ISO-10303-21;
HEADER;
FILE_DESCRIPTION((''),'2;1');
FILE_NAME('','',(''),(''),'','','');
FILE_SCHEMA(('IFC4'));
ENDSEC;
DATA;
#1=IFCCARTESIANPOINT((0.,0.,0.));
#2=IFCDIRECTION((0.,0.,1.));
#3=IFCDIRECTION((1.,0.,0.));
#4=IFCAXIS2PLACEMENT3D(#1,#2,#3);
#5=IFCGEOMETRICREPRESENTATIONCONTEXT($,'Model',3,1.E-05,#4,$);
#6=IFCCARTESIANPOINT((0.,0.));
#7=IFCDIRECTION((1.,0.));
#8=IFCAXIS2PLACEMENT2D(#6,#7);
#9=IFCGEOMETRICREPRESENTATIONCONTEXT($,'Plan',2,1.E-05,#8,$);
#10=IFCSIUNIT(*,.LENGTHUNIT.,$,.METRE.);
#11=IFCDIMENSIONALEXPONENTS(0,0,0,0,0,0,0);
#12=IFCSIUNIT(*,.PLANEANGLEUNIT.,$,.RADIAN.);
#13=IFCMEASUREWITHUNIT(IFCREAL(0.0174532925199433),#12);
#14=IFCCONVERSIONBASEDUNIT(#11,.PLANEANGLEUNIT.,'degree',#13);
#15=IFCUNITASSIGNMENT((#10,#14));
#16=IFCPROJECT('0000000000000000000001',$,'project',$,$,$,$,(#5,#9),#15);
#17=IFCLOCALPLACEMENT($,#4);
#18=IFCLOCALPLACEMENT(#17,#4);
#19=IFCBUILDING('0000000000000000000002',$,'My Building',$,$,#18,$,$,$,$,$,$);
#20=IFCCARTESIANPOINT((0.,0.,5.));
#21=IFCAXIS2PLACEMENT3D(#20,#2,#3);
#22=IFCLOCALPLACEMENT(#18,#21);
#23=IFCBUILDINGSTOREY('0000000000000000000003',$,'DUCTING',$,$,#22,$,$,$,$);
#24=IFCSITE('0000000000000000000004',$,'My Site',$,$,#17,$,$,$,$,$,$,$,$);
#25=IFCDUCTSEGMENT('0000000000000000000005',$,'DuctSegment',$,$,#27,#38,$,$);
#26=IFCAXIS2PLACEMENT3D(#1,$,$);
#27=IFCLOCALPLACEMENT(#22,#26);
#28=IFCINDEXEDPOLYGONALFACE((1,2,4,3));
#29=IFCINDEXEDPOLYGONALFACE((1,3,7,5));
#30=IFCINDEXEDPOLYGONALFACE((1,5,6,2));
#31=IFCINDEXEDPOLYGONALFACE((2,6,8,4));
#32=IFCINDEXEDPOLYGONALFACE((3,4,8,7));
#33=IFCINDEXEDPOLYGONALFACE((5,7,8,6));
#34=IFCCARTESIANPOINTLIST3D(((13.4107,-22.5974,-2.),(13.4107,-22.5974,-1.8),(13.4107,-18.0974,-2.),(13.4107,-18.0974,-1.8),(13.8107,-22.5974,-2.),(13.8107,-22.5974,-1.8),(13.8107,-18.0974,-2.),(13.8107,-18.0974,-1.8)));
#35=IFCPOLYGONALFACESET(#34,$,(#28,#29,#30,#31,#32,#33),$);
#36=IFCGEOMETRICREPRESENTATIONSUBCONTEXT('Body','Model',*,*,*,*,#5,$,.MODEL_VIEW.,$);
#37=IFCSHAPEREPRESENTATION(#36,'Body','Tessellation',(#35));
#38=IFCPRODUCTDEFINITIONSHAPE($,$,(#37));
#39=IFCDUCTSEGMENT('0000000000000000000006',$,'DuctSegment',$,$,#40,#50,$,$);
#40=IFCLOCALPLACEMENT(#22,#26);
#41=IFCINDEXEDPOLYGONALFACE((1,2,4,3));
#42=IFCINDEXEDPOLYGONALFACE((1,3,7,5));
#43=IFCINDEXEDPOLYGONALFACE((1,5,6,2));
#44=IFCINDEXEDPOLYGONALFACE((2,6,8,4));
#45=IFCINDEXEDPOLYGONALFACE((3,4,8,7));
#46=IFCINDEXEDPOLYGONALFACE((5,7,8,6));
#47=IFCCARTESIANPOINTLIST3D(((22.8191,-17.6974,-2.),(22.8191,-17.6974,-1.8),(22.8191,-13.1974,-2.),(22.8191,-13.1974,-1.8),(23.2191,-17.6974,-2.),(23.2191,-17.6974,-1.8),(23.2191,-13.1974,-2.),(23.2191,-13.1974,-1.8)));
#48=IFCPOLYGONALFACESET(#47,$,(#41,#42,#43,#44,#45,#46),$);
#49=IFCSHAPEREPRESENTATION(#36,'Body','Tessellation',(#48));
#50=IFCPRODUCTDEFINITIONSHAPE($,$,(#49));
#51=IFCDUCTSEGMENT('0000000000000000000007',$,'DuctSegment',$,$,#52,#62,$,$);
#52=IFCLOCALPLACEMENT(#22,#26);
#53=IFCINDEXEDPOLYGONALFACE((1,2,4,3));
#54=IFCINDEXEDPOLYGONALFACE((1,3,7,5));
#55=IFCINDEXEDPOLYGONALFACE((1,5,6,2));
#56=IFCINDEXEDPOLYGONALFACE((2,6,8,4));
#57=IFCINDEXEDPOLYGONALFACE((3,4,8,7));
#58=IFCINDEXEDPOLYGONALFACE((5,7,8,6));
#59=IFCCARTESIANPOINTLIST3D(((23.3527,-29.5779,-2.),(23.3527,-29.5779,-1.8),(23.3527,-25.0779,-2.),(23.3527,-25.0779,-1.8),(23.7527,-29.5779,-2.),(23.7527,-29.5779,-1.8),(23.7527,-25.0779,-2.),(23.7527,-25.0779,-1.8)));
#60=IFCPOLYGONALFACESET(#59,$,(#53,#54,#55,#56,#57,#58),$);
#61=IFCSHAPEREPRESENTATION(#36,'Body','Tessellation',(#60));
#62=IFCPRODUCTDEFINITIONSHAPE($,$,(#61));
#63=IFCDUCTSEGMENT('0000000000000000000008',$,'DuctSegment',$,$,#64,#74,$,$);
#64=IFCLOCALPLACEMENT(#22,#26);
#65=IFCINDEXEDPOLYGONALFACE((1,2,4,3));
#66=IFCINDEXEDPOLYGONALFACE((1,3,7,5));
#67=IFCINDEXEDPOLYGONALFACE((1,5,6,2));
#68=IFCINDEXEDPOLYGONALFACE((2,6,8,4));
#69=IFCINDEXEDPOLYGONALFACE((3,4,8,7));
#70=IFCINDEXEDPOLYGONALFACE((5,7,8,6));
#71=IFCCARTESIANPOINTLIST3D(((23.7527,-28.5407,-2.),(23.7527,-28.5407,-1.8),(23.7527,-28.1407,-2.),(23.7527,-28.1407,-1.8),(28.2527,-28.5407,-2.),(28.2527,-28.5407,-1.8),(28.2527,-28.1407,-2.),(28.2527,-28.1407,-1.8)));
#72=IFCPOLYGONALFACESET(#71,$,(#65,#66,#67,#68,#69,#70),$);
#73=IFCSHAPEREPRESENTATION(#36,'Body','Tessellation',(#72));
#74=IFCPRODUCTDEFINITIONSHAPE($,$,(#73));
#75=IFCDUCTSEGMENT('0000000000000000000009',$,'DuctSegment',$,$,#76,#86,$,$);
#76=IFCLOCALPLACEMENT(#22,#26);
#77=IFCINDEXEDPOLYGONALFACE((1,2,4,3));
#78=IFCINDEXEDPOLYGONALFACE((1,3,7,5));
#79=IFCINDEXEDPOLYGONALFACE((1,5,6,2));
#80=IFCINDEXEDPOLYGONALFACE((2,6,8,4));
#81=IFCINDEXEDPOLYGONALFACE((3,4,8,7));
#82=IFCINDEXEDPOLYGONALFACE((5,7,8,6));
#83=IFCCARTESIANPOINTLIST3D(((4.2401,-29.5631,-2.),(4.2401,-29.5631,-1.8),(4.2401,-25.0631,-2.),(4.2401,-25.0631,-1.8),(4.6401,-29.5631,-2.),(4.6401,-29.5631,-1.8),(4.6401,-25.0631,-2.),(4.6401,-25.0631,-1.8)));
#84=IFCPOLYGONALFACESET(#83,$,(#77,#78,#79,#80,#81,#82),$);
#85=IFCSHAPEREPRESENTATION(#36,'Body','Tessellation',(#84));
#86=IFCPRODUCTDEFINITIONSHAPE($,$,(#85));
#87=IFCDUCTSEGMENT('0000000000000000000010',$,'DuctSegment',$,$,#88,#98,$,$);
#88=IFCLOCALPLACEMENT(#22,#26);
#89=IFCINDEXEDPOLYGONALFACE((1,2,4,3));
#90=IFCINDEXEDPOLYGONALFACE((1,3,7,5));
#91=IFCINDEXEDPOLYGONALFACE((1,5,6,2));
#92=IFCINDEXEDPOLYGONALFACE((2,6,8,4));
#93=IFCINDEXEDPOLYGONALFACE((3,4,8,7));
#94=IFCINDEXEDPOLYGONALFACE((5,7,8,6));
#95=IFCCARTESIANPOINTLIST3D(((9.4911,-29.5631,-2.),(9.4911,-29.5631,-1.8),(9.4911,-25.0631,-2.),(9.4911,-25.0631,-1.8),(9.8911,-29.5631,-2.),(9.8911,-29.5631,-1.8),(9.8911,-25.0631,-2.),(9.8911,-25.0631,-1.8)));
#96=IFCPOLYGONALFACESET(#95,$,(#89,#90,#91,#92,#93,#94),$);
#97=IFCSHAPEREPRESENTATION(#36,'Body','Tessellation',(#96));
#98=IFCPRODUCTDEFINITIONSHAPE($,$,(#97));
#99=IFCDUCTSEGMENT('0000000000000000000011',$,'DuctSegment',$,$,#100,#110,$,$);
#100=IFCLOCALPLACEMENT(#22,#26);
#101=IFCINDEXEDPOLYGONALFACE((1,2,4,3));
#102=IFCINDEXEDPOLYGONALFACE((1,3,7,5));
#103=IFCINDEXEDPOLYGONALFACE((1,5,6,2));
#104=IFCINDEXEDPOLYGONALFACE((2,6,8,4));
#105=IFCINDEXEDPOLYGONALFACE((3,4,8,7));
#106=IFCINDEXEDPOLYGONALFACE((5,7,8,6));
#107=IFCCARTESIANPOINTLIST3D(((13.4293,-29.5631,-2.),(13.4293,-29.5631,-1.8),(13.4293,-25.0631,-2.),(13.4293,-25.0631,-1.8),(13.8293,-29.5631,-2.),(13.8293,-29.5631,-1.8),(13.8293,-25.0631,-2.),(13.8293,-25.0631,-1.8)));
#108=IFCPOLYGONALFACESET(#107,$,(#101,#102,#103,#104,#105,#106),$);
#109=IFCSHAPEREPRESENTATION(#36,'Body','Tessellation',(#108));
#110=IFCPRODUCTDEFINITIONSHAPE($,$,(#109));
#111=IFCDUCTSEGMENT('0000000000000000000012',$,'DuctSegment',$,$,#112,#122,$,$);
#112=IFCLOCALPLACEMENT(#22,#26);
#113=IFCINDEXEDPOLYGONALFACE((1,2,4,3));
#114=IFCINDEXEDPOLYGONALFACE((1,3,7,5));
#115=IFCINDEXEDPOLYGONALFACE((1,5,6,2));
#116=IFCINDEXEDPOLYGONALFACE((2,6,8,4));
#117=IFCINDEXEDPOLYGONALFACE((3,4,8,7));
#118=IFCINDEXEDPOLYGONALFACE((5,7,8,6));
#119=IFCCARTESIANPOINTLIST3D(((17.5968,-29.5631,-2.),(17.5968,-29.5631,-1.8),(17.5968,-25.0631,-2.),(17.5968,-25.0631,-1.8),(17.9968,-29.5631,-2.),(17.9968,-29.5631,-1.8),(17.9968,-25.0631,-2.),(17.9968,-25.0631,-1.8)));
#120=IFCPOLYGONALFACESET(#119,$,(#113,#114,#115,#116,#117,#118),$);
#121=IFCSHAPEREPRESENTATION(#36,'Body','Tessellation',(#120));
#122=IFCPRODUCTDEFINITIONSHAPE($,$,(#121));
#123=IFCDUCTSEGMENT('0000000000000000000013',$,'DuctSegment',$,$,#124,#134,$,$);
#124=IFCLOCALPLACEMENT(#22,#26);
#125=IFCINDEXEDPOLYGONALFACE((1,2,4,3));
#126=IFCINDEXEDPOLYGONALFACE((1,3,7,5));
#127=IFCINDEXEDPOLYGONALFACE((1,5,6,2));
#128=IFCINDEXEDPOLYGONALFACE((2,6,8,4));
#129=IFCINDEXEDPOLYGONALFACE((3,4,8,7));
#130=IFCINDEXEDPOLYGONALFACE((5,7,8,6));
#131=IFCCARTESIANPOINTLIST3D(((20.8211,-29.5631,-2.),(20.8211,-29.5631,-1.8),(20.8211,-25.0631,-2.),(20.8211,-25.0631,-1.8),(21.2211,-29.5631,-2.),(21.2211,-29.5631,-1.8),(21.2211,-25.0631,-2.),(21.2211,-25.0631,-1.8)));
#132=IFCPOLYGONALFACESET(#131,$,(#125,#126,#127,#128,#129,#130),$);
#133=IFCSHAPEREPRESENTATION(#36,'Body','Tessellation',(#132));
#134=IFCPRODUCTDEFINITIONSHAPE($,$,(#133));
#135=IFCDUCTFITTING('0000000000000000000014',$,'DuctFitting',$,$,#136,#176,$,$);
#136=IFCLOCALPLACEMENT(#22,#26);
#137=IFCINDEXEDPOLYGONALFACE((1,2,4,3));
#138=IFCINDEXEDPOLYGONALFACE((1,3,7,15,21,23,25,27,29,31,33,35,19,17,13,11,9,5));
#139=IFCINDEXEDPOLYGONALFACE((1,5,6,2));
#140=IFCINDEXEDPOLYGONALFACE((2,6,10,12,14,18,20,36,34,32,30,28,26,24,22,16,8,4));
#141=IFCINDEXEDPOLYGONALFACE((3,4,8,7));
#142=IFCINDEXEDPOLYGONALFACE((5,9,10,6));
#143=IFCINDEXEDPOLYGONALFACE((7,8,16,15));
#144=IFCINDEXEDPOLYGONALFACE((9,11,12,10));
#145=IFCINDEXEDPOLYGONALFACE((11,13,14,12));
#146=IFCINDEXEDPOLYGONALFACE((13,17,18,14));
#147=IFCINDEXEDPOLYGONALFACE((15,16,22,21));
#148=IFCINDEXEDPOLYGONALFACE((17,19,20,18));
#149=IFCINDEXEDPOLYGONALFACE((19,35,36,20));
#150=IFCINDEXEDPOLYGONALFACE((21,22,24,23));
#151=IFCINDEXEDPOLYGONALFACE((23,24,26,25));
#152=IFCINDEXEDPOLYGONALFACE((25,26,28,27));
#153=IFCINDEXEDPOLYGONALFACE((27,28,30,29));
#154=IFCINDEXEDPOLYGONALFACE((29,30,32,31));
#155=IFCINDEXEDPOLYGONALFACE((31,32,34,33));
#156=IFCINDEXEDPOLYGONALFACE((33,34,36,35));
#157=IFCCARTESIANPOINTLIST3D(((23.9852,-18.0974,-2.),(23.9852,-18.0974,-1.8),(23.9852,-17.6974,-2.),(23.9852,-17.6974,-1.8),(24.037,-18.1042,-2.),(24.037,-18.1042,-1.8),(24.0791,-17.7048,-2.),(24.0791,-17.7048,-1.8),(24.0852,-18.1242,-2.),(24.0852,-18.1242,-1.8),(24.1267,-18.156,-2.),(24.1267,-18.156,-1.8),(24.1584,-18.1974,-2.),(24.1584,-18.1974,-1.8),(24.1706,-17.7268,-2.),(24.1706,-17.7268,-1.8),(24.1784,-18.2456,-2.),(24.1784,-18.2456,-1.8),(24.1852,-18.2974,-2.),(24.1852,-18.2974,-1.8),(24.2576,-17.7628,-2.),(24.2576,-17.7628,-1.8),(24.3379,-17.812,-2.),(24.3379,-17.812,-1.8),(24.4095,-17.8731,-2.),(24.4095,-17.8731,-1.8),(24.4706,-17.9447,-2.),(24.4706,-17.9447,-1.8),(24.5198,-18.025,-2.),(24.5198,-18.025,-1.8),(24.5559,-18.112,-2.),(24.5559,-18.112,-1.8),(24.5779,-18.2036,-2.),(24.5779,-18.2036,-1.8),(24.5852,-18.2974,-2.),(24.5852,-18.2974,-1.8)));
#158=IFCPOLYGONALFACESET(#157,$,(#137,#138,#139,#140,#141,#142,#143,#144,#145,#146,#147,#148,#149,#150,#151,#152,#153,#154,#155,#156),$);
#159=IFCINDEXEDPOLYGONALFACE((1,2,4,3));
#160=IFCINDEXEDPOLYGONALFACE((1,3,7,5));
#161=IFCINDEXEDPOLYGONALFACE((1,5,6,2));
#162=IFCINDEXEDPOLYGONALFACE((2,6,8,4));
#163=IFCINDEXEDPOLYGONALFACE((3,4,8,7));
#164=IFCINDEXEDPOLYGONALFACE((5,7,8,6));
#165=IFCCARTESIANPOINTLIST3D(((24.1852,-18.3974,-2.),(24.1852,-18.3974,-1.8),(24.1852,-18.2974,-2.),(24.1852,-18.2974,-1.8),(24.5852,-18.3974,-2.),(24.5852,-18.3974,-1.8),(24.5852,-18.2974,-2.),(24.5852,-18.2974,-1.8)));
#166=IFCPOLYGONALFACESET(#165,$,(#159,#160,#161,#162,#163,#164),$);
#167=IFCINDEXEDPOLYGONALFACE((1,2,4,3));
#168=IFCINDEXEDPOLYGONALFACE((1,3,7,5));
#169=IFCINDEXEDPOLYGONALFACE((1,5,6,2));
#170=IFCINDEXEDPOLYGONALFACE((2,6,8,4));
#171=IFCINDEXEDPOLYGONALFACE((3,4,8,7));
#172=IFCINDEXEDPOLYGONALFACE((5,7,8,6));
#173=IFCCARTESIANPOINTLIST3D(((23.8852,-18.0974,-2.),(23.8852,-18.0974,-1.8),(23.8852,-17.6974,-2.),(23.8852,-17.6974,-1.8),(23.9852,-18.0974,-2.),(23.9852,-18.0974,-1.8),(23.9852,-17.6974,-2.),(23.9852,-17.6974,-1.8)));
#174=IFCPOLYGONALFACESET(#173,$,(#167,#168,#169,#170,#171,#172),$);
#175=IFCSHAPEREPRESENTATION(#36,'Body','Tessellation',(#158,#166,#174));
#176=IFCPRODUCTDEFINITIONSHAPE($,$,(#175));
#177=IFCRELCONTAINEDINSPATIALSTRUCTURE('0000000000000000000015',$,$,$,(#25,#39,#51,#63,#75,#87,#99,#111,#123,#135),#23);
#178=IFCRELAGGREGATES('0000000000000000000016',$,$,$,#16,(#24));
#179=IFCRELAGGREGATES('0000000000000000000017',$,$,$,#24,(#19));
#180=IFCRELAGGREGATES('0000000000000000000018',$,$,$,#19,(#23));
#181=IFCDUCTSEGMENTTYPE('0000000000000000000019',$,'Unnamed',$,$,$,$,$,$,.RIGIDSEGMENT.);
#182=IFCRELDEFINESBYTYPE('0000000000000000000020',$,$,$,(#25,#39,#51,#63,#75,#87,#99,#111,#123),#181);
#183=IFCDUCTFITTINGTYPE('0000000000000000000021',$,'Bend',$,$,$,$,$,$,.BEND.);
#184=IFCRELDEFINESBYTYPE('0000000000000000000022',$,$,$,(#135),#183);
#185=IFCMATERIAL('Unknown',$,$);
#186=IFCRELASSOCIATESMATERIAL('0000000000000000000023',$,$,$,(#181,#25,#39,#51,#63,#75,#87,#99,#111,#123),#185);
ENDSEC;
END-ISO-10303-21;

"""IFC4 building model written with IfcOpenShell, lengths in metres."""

from ifc_helpers import new_model, entity, si_unit, converted_unit, frame, origin_with_axes, origin_2d_with_axis, place, context, subcontext, project, spatial, line, arc, indexed_curve, rectangle, outline, extrude, source, transform, mapped, material, material_profile, profile_set, profile_usage, type_object, type_shapes, element, save


model = new_model("IFC4")

# Units and contexts
model_context = context("Model", 3, precision=1e-05, world=origin_with_axes())
plan_context = context("Plan", 2, precision=1e-05, world=origin_2d_with_axis())
body_context = subcontext(model_context, "Body", "Model", "MODEL_VIEW")
ifc_project = project(units=[si_unit("LENGTHUNIT", "METRE"), converted_unit("PLANEANGLEUNIT", "degree", entity("IfcReal", 0.0174532925199433), si_unit("PLANEANGLEUNIT", "RADIAN"), dimensions=[0, 0, 0, 0, 0, 0, 0])], contexts=[model_context, plan_context])

# Site, building, storey
site_placement = place(None, origin_with_axes())
site = spatial("IfcSite", under=ifc_project, at=site_placement, Name="My Site")
building_placement = place(site_placement, origin_with_axes())
building = spatial("IfcBuilding", under=site, at=building_placement, Name="My Building")
storey_placement = place(building_placement, frame((0.0, 0.0, 5.0), z_axis=(0.0, 0.0, 1.0), x_axis=(1.0, 0.0, 0.0)))
storey = spatial("IfcBuildingStorey", under=building, at=storey_placement, Name="DUCTING")

# Duct segments
ifc_material = material(Name="Unknown")
ifc_material_profile = material_profile(ifc_material, rectangle(XDim=0.4, YDim=0.2))
ifc_profile_set = profile_set([ifc_material_profile])
duct_segment_type = type_object("IfcDuctSegmentType", Name="Unnamed", PredefinedType="RIGIDSEGMENT", material=ifc_profile_set)
ifc_profile_usage_1 = profile_usage(ifc_profile_set, cardinal=5)
duct_segment_1_placement = place(storey_placement, frame((13.6107, -22.5974, -1.9), z_axis=(0.0, 1.0, -0.000003), x_axis=(-1.0, 0.0, 0.0)))
element("IfcDuctSegment", 1, at=duct_segment_1_placement, inside=storey, type_object=duct_segment_type, material=ifc_profile_usage_1, Name="DuctSegment", context=body_context, shape_type="SweptSolid", body=[
    extrude(rectangle(XDim=0.4, YDim=0.2), origin_with_axes(), (0.0, 0.0, 1.0), 4.5),
])
ifc_profile_usage_2 = profile_usage(ifc_profile_set, cardinal=5)
duct_segment_2_placement = place(storey_placement, frame((23.0191, -17.6974, -1.9), z_axis=(0.0, 1.0, -0.000003), x_axis=(-1.0, 0.0, 0.0)))
element("IfcDuctSegment", 2, at=duct_segment_2_placement, inside=storey, type_object=duct_segment_type, material=ifc_profile_usage_2, Name="DuctSegment", context=body_context, shape_type="SweptSolid", body=[
    extrude(rectangle(XDim=0.4, YDim=0.2), origin_with_axes(), (0.0, 0.0, 1.0), 4.5),
])
ifc_profile_usage_3 = profile_usage(ifc_profile_set, cardinal=5)
duct_segment_3_placement = place(storey_placement, frame((23.5527, -29.5779, -1.9), z_axis=(0.0, 1.0, -0.000003), x_axis=(-1.0, 0.0, 0.0)))
element("IfcDuctSegment", 3, at=duct_segment_3_placement, inside=storey, type_object=duct_segment_type, material=ifc_profile_usage_3, Name="DuctSegment", context=body_context, shape_type="SweptSolid", body=[
    extrude(rectangle(XDim=0.4, YDim=0.2), origin_with_axes(), (0.0, 0.0, 1.0), 4.5),
])
ifc_profile_usage_4 = profile_usage(ifc_profile_set, cardinal=5)
duct_segment_4_placement = place(storey_placement, frame((28.2527, -28.3407, -1.9), z_axis=(-1.0, 0.0, -0.000003), x_axis=(0.0, -1.0, 0.0)))
element("IfcDuctSegment", 4, at=duct_segment_4_placement, inside=storey, type_object=duct_segment_type, material=ifc_profile_usage_4, Name="DuctSegment", context=body_context, shape_type="SweptSolid", body=[
    extrude(rectangle(XDim=0.4, YDim=0.2), origin_with_axes(), (0.0, 0.0, 1.0), 4.5),
])
ifc_profile_usage_5 = profile_usage(ifc_profile_set, cardinal=5)
duct_segment_5_placement = place(storey_placement, frame((4.4401, -29.5631, -1.9), z_axis=(0.0, 1.0, -0.000003), x_axis=(-1.0, 0.0, 0.0)))
element("IfcDuctSegment", 5, at=duct_segment_5_placement, inside=storey, type_object=duct_segment_type, material=ifc_profile_usage_5, Name="DuctSegment", context=body_context, shape_type="SweptSolid", body=[
    extrude(rectangle(XDim=0.4, YDim=0.2), origin_with_axes(), (0.0, 0.0, 1.0), 4.5),
])
ifc_profile_usage_6 = profile_usage(ifc_profile_set, cardinal=5)
duct_segment_6_placement = place(storey_placement, frame((9.6911, -29.5631, -1.9), z_axis=(0.0, 1.0, -0.000003), x_axis=(-1.0, 0.0, 0.0)))
element("IfcDuctSegment", 6, at=duct_segment_6_placement, inside=storey, type_object=duct_segment_type, material=ifc_profile_usage_6, Name="DuctSegment", context=body_context, shape_type="SweptSolid", body=[
    extrude(rectangle(XDim=0.4, YDim=0.2), origin_with_axes(), (0.0, 0.0, 1.0), 4.5),
])
ifc_profile_usage_7 = profile_usage(ifc_profile_set, cardinal=5)
duct_segment_7_placement = place(storey_placement, frame((13.6293, -29.5631, -1.9), z_axis=(0.0, 1.0, -0.000003), x_axis=(-1.0, 0.0, 0.0)))
element("IfcDuctSegment", 7, at=duct_segment_7_placement, inside=storey, type_object=duct_segment_type, material=ifc_profile_usage_7, Name="DuctSegment", context=body_context, shape_type="SweptSolid", body=[
    extrude(rectangle(XDim=0.4, YDim=0.2), origin_with_axes(), (0.0, 0.0, 1.0), 4.5),
])
ifc_profile_usage_8 = profile_usage(ifc_profile_set, cardinal=5)
duct_segment_8_placement = place(storey_placement, frame((17.7968, -29.5631, -1.9), z_axis=(0.0, 1.0, -0.000003), x_axis=(-1.0, 0.0, 0.0)))
element("IfcDuctSegment", 8, at=duct_segment_8_placement, inside=storey, type_object=duct_segment_type, material=ifc_profile_usage_8, Name="DuctSegment", context=body_context, shape_type="SweptSolid", body=[
    extrude(rectangle(XDim=0.4, YDim=0.2), origin_with_axes(), (0.0, 0.0, 1.0), 4.5),
])
ifc_profile_usage_9 = profile_usage(ifc_profile_set, cardinal=5)
duct_segment_9_placement = place(storey_placement, frame((21.0211, -29.5631, -1.9), z_axis=(0.0, 1.0, -0.000003), x_axis=(-1.0, 0.0, 0.0)))
element("IfcDuctSegment", 9, at=duct_segment_9_placement, inside=storey, type_object=duct_segment_type, material=ifc_profile_usage_9, Name="DuctSegment", context=body_context, shape_type="SweptSolid", body=[
    extrude(rectangle(XDim=0.4, YDim=0.2), origin_with_axes(), (0.0, 0.0, 1.0), 4.5),
])

# Duct fitting
duct_fitting_type = type_object("IfcDuctFittingType", Name="Bend", PredefinedType="BEND")
shared_shape = source(origin_with_axes(), body_context, "Body", "SweptSolid", [
    extrude(outline(indexed_curve([(-0.2, 0.0), (-0.2586, -0.1414), (-0.4, -0.2), (-0.4, -0.6), (0.0243, -0.4243), (0.2, 0.0)], segments=[arc(1, 2, 3), line(3, 4), arc(4, 5, 6), line(6, 1)])), frame((0.0, -0.1, -0.1), z_axis=(0.0, -1.0, 0.0), x_axis=(1.0, 0.0, 0.0)), (0.0, 0.0, -1.0), 0.2),
    extrude(rectangle(XDim=0.4, YDim=0.2), origin_with_axes(), (0.0, 0.0, -1.0), 0.1),
    extrude(rectangle(XDim=0.4, YDim=0.2), frame((-0.4, 0.0, -0.5), z_axis=(-1.0, 0.0, 0.0), x_axis=(0.0, 0.0, -1.0)), (0.0, 0.0, 1.0), 0.1),
])
type_shapes(duct_fitting_type, [shared_shape])
for number, where, z_axis, x_axis, name in (
    (10, (24.3852, -18.3974, -1.9), (0.0, -1.0, 0.0), (1.0, 0.0, 0.0), "DuctFitting"),
):
    element("IfcDuctFitting", number, at=place(storey_placement, frame(where, z_axis=z_axis, x_axis=x_axis)), inside=storey, type_object=duct_fitting_type, Name=name, context=body_context, shape_type="MappedRepresentation", body=[
        mapped(shared_shape, transform((0.0, 0.0, 0.0), x_axis=(1.0, 0.0, 0.0), y_axis=(0.0, 1.0, 0.0), z_axis=(0.0, 0.0, 1.0), scale=1.0)),
    ])

save(model, "model.ifc")
